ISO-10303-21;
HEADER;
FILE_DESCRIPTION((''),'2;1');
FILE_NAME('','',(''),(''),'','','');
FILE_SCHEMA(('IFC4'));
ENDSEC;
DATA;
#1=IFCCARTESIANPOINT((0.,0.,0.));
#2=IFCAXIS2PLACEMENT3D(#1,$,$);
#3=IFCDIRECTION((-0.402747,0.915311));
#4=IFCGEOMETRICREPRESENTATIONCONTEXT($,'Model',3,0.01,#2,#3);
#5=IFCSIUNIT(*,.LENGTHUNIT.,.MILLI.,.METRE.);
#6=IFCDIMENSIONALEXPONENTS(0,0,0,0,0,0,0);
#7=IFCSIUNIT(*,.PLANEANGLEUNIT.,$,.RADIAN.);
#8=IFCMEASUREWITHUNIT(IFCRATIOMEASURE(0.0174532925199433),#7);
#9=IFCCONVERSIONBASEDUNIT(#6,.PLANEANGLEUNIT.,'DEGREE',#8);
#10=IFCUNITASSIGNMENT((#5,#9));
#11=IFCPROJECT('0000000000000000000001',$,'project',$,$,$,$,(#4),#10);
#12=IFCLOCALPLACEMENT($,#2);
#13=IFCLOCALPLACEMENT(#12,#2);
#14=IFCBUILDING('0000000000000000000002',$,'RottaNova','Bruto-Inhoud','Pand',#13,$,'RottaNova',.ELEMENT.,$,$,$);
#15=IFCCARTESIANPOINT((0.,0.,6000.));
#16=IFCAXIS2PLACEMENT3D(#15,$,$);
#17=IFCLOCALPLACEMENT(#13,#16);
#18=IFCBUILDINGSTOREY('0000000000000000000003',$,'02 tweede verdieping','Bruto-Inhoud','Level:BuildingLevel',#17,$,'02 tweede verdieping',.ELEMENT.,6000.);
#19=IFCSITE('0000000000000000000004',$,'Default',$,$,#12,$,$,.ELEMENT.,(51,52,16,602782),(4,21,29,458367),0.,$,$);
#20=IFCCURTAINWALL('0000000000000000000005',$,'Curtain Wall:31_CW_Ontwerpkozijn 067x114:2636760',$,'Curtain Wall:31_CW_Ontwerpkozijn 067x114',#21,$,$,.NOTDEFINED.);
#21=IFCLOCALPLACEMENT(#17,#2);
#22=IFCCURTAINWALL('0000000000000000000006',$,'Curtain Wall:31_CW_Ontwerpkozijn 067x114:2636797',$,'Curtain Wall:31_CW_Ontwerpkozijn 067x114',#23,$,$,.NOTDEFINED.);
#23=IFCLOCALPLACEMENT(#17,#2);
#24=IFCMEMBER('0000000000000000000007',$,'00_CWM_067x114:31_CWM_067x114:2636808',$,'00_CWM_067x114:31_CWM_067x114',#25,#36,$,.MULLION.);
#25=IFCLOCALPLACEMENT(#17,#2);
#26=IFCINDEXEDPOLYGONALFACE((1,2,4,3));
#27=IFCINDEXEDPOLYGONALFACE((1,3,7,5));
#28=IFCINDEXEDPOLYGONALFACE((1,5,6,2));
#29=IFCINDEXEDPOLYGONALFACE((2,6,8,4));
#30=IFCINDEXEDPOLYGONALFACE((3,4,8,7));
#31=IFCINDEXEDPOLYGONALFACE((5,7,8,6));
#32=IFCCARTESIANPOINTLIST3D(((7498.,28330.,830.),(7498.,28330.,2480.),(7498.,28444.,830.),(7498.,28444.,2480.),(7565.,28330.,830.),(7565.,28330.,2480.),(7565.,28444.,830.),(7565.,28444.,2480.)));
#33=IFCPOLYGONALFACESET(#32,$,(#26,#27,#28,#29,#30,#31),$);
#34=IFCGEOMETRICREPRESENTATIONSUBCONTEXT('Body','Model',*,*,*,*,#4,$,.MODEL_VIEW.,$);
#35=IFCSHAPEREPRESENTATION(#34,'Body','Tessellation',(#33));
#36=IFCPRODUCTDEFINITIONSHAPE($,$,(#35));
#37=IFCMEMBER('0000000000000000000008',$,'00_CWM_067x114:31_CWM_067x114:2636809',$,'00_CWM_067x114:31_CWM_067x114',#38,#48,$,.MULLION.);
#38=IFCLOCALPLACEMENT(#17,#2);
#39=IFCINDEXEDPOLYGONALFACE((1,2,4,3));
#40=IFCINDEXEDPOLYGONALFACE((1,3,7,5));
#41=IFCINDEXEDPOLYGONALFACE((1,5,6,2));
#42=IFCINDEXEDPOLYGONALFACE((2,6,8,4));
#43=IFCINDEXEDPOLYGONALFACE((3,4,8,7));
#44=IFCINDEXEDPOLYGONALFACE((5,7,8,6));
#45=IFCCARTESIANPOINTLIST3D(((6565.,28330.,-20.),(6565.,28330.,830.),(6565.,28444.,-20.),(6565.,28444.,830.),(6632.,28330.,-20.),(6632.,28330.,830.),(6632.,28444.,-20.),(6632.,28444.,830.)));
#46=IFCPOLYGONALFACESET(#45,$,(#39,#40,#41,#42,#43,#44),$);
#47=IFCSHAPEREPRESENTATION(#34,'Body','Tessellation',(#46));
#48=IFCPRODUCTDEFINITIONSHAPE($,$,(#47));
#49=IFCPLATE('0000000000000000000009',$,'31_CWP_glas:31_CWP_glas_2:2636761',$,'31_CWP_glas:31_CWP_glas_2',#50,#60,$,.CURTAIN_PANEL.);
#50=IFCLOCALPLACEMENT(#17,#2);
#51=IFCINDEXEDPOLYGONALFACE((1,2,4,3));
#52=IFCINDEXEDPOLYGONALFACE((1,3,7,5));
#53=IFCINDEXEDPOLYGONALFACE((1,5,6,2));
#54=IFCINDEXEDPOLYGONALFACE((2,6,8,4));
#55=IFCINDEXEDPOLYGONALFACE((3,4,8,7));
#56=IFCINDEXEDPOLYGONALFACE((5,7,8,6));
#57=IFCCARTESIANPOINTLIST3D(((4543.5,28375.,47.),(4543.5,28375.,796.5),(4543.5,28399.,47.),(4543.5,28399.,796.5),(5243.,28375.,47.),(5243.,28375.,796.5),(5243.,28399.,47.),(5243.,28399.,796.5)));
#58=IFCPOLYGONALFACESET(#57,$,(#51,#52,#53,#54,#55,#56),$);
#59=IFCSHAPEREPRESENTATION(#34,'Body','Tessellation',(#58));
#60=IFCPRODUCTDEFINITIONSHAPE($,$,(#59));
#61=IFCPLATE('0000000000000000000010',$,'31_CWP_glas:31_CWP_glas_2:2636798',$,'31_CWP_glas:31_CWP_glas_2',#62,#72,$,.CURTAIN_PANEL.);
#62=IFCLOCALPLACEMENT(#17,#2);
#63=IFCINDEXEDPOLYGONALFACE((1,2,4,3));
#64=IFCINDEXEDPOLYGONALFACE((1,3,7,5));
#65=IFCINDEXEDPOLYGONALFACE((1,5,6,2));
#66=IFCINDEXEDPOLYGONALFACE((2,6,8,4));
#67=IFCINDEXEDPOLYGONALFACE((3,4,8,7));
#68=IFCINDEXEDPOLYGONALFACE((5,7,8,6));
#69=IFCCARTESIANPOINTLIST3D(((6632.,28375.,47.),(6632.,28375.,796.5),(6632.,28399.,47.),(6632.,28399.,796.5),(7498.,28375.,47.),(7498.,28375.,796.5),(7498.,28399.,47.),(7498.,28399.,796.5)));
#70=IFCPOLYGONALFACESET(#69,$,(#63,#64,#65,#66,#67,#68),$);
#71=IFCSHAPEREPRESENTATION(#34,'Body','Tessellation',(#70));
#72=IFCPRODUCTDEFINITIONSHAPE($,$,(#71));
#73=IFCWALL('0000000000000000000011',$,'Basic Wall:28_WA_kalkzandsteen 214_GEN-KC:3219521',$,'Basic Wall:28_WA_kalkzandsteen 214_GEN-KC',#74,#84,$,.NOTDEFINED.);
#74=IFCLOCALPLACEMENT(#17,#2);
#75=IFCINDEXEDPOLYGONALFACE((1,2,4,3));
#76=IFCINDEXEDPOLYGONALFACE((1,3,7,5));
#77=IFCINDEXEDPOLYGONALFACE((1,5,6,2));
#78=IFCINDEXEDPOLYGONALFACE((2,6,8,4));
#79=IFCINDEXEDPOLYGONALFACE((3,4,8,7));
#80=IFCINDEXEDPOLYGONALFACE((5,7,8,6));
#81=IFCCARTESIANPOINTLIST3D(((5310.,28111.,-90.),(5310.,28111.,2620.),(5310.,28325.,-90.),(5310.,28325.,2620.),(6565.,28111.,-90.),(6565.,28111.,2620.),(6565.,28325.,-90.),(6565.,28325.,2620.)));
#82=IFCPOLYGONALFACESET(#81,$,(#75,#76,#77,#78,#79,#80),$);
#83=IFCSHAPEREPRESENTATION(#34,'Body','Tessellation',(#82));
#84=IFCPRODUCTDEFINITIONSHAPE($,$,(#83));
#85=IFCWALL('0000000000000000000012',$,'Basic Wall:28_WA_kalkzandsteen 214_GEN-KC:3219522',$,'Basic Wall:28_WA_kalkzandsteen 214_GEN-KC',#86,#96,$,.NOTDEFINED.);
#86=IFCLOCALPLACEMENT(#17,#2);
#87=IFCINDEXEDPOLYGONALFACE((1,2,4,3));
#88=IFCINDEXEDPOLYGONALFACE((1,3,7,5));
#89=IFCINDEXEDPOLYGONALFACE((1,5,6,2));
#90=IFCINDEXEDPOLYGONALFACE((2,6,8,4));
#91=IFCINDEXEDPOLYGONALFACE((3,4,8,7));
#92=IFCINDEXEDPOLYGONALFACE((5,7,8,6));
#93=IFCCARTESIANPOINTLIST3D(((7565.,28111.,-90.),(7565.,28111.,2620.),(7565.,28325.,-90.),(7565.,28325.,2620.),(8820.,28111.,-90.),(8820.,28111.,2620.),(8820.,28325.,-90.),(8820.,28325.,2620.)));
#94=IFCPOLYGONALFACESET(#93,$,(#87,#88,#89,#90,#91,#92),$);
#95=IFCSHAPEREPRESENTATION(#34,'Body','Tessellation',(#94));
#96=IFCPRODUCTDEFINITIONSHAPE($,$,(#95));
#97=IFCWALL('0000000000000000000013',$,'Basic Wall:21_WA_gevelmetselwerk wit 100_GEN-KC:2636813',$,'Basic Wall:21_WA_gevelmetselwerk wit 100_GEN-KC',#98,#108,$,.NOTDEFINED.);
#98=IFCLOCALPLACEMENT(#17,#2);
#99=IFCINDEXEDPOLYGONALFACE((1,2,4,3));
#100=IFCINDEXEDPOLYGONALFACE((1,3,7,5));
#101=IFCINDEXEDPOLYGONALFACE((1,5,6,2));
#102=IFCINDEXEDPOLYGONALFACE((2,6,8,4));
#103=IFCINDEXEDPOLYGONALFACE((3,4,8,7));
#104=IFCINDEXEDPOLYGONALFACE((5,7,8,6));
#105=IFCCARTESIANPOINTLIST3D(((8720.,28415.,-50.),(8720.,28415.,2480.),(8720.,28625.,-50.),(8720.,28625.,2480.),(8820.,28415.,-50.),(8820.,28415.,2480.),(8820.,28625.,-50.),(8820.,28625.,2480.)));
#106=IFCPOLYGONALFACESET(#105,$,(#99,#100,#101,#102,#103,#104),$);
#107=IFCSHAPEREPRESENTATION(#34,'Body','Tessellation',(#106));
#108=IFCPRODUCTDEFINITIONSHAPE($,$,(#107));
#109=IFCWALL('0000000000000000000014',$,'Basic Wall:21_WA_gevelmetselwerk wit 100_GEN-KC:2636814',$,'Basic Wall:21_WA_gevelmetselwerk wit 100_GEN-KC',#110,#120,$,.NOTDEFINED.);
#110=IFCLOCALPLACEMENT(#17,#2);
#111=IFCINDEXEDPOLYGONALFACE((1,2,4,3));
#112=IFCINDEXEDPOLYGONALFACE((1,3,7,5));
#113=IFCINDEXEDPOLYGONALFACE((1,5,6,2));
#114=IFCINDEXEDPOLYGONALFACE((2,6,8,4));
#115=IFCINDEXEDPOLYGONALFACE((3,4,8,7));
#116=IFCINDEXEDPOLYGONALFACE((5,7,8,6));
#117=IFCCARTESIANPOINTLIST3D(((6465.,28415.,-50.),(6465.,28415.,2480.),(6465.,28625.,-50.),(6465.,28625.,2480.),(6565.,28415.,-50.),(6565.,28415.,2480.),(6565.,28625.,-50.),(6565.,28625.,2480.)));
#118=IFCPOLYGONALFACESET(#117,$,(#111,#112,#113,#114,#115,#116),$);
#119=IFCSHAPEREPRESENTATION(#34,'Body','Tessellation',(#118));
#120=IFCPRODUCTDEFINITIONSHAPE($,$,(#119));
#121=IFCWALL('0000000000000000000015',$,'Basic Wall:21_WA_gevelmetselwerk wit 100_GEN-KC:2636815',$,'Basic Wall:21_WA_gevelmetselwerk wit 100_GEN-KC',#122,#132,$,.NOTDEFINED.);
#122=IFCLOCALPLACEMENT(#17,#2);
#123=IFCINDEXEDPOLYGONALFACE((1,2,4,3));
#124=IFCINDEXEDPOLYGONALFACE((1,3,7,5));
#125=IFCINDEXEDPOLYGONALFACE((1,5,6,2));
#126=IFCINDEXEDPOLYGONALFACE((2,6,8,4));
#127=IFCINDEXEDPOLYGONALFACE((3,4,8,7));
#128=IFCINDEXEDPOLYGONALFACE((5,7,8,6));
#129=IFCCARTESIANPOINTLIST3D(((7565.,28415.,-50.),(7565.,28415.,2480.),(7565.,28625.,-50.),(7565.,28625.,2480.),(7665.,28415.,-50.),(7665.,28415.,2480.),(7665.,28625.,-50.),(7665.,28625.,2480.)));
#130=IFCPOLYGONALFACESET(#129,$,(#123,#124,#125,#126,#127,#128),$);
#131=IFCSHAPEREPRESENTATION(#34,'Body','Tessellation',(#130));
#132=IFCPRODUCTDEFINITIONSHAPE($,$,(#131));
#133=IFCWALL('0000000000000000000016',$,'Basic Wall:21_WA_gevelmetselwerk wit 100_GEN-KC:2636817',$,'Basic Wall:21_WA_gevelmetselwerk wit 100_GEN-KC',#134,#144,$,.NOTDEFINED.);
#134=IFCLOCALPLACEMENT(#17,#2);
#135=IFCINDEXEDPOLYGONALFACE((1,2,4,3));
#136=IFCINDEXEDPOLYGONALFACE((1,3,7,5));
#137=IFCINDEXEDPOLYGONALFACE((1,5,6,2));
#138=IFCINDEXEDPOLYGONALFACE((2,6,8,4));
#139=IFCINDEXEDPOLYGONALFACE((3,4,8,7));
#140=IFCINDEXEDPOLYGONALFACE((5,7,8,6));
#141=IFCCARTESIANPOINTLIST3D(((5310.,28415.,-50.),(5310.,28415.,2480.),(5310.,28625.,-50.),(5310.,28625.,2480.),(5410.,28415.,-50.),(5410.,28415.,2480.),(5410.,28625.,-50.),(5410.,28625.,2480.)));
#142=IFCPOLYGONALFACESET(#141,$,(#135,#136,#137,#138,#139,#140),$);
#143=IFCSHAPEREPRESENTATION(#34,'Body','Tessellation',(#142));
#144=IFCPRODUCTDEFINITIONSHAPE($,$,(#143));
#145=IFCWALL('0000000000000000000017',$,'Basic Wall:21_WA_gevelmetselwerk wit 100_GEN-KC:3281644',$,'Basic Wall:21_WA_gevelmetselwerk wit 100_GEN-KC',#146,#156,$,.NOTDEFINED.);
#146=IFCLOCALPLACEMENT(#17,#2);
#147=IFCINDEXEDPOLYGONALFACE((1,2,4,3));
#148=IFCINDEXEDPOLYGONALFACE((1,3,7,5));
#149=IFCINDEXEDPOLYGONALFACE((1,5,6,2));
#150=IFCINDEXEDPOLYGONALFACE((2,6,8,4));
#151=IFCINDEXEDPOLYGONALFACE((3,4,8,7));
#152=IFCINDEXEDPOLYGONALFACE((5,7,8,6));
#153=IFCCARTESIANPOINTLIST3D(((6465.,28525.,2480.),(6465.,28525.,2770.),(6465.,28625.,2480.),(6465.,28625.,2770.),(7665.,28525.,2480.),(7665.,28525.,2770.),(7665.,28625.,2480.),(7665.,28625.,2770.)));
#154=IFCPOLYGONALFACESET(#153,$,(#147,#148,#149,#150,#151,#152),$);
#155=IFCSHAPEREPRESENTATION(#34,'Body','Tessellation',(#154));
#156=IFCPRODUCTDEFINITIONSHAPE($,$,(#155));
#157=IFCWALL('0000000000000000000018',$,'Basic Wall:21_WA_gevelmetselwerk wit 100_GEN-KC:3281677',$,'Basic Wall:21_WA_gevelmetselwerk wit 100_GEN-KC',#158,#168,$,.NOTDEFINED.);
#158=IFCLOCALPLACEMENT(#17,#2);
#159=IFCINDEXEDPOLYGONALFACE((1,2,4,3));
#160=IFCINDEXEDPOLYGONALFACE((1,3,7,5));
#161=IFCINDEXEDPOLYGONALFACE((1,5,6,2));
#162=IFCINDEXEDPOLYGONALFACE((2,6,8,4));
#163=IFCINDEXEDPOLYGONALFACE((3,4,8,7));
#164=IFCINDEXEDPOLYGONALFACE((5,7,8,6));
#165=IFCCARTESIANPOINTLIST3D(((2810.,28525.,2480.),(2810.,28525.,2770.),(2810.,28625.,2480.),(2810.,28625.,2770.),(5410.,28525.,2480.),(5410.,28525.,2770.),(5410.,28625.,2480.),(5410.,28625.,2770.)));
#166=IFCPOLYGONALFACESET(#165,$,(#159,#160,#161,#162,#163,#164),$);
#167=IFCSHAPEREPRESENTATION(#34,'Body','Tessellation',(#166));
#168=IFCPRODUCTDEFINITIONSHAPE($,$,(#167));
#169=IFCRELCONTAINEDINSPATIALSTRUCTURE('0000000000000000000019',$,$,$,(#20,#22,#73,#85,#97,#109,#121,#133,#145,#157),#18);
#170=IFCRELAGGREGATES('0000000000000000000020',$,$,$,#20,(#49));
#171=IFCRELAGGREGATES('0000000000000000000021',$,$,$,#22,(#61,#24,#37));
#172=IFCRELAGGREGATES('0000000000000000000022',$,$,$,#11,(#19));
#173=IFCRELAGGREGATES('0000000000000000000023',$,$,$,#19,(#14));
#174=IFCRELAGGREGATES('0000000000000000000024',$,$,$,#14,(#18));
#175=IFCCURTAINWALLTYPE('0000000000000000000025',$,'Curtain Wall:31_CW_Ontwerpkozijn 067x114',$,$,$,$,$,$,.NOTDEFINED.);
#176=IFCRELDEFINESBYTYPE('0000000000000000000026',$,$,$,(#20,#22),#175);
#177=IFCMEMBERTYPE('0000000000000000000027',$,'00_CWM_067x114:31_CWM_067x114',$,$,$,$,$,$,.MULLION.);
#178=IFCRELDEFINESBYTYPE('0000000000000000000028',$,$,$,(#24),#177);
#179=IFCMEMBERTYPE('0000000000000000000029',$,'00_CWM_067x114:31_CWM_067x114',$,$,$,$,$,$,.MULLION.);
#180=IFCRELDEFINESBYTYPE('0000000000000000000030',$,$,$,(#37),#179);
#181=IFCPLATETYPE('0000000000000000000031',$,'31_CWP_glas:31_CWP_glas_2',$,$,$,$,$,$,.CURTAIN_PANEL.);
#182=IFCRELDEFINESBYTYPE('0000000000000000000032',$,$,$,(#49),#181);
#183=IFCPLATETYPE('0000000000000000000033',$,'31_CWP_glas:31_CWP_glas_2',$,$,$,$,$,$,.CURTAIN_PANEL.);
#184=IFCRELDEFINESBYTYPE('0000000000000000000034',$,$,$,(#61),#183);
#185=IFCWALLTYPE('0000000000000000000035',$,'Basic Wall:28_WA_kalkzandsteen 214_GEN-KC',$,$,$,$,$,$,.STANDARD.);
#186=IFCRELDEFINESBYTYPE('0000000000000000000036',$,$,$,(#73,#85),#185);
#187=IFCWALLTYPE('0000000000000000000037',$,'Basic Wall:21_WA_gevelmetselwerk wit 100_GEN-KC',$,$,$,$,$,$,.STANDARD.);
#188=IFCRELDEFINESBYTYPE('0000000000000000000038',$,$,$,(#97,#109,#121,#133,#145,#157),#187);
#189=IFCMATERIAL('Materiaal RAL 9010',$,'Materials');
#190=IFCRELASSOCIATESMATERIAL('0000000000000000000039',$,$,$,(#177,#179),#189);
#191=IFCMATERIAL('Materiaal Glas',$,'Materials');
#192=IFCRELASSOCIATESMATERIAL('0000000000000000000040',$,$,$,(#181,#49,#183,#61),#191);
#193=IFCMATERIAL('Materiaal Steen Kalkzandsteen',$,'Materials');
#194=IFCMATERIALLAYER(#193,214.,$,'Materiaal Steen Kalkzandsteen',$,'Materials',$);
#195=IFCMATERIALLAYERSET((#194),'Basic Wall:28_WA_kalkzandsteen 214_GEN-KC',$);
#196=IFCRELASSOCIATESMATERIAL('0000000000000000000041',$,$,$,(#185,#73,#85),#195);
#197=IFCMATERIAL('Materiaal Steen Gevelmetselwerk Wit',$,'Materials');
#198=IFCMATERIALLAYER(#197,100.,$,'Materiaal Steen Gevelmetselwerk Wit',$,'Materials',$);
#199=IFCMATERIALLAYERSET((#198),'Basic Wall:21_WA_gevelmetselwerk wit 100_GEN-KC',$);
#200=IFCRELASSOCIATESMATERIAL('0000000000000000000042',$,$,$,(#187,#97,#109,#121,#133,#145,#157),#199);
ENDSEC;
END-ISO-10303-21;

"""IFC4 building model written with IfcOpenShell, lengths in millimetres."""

from ifc_helpers import new_model, entity, si_unit, converted_unit, direction, frame, frame_2d, origin, origin_2d_with_axis, place, context, subcontext, project, spatial, rectangle, extrude, source, transform, mapped, material, layer, layer_set, material_profile, profile_set, type_object, type_shapes, element, aggregate, save


model = new_model("IFC4")

# Units and contexts
model_context = context("Model", 3, precision=0.01, world=origin(), true_north=direction((-0.402747, 0.915311)))
body_context = subcontext(model_context, "Body", "Model", "MODEL_VIEW")
ifc_project = project(units=[si_unit("LENGTHUNIT", "METRE", prefix="MILLI"), converted_unit("PLANEANGLEUNIT", "DEGREE", entity("IfcRatioMeasure", 0.0174532925199433), si_unit("PLANEANGLEUNIT", "RADIAN"), dimensions=[0, 0, 0, 0, 0, 0, 0])], contexts=[model_context])

# Site, building, storey
site_placement = place(None, origin())
site = spatial("IfcSite", under=ifc_project, at=site_placement, Name="Default", CompositionType="ELEMENT", RefLatitude=(51, 52, 16, 602782), RefLongitude=(4, 21, 29, 458367), RefElevation=0.0)
building_placement = place(site_placement, origin())
building = spatial("IfcBuilding", under=site, at=building_placement, Name="RottaNova", Description="Bruto-Inhoud", ObjectType="Pand", LongName="RottaNova", CompositionType="ELEMENT")
storey_placement = place(building_placement, frame((0.0, 0.0, 6000.0)))
storey = spatial("IfcBuildingStorey", under=building, at=storey_placement, Name="02 tweede verdieping", Description="Bruto-Inhoud", ObjectType="Level:BuildingLevel", LongName="02 tweede verdieping", CompositionType="ELEMENT", Elevation=6000.0)

# Shared definitions
curtain_wall_type = type_object("IfcCurtainWallType", Name="Curtain Wall:31_CW_Ontwerpkozijn 067x114", PredefinedType="NOTDEFINED")
ifc_material_1 = material(Name="Materiaal RAL 9010", Category="Materials")
ifc_material_profile = material_profile(ifc_material_1, rectangle(XDim=114.0, YDim=67.0, at=origin_2d_with_axis()), Name="31_CWM_067x114")
ifc_profile_set = profile_set([ifc_material_profile], Name="31_CWM_067x114")

# Curtain walls
curtain_wall_1_placement = place(storey_placement, frame((0.0, 0.0, -6000.0)))
curtain_wall_1 = element("IfcCurtainWall", 1, at=curtain_wall_1_placement, inside=storey, type_object=curtain_wall_type, Name="Curtain Wall:31_CW_Ontwerpkozijn 067x114:2636760", ObjectType="Curtain Wall:31_CW_Ontwerpkozijn 067x114", PredefinedType="NOTDEFINED")
curtain_wall_2_placement = place(storey_placement, frame((0.0, 0.0, -6000.0)))
curtain_wall_2 = element("IfcCurtainWall", 2, at=curtain_wall_2_placement, inside=storey, type_object=curtain_wall_type, Name="Curtain Wall:31_CW_Ontwerpkozijn 067x114:2636797", ObjectType="Curtain Wall:31_CW_Ontwerpkozijn 067x114", PredefinedType="NOTDEFINED")

# Members
member_type_1 = type_object("IfcMemberType", Name="00_CWM_067x114:31_CWM_067x114", PredefinedType="MULLION", material=ifc_profile_set)
shared_shape_1 = source(origin(), body_context, "Body", "SweptSolid", [
    extrude(rectangle(XDim=114.0, YDim=67.0, at=frame_2d((0.0, 0.0), x_axis=(1.0, 0.0))), frame((-33.5, -57.0, -1650.0), z_axis=(0.0, 0.0, 1.0), x_axis=(0.0, -1.0, 0.0)), (0.0, 0.0, 1.0), 1650.0),
])
type_shapes(member_type_1, [shared_shape_1])
member_1_placement = place(curtain_wall_2_placement, frame((7565.0, 28330.0, 6830.0), z_axis=(0.0, 0.0, -1.0), x_axis=(1.0, 0.0, 0.0)))
member_1 = element("IfcMember", 3, at=member_1_placement, type_object=member_type_1, Name="00_CWM_067x114:31_CWM_067x114:2636808", ObjectType="00_CWM_067x114:31_CWM_067x114", PredefinedType="MULLION", context=body_context, shape_type="MappedRepresentation", body=[
    mapped(shared_shape_1, transform((0.0, 0.0, 0.0), scale=1.0)),
])
member_type_2 = type_object("IfcMemberType", Name="00_CWM_067x114:31_CWM_067x114", PredefinedType="MULLION", material=ifc_profile_set)
shared_shape_2 = source(origin(), body_context, "Body", "SweptSolid", [
    extrude(rectangle(XDim=114.0, YDim=67.0, at=frame_2d((0.0, 0.0), x_axis=(1.0, 0.0))), frame((-33.5, -57.0, -850.0), z_axis=(0.0, 0.0, 1.0), x_axis=(0.0, -1.0, 0.0)), (0.0, 0.0, 1.0), 850.0),
])
type_shapes(member_type_2, [shared_shape_2])
member_2_placement = place(curtain_wall_2_placement, frame((6565.0, 28330.0, 6830.0), z_axis=(0.0, 0.0, 1.0), x_axis=(-1.0, 0.0, 0.0)))
member_2 = element("IfcMember", 4, at=member_2_placement, type_object=member_type_2, Name="00_CWM_067x114:31_CWM_067x114:2636809", ObjectType="00_CWM_067x114:31_CWM_067x114", PredefinedType="MULLION", context=body_context, shape_type="MappedRepresentation", body=[
    mapped(shared_shape_2, transform((0.0, 0.0, 0.0), scale=1.0)),
])

# Plates
ifc_material_2 = material(Name="Materiaal Glas", Category="Materials")
plate_type_1 = type_object("IfcPlateType", Name="31_CWP_glas:31_CWP_glas_2", PredefinedType="CURTAIN_PANEL", material=ifc_material_2)
shared_shape_3 = source(origin(), body_context, "Body", "SweptSolid", [
    extrude(rectangle(XDim=24.0, YDim=699.5, at=frame_2d((0.0, 0.0), x_axis=(1.0, 0.0))), frame((349.8, 12.0, 0.0), z_axis=(0.0, 0.0, 1.0), x_axis=(0.0, 1.0, 0.0)), (0.0, 0.0, 1.0), 749.5),
])
type_shapes(plate_type_1, [shared_shape_3])
plate_1_placement = place(curtain_wall_1_placement, frame((5243.0, 28399.0, 6047.0), z_axis=(0.0, 0.0, 1.0), x_axis=(-1.0, 0.0, 0.0)))
plate_1 = element("IfcPlate", 5, at=plate_1_placement, type_object=plate_type_1, material=ifc_material_2, Name="31_CWP_glas:31_CWP_glas_2:2636761", ObjectType="31_CWP_glas:31_CWP_glas_2", PredefinedType="CURTAIN_PANEL", context=body_context, shape_type="MappedRepresentation", body=[
    mapped(shared_shape_3, transform((0.0, 0.0, 0.0), scale=1.0)),
])
plate_type_2 = type_object("IfcPlateType", Name="31_CWP_glas:31_CWP_glas_2", PredefinedType="CURTAIN_PANEL", material=ifc_material_2)
shared_shape_4 = source(origin(), body_context, "Body", "SweptSolid", [
    extrude(rectangle(XDim=24.0, YDim=866.0, at=frame_2d((0.0, 0.0), x_axis=(1.0, 0.0))), frame((433.0, 12.0, 0.0), z_axis=(0.0, 0.0, 1.0), x_axis=(0.0, 1.0, 0.0)), (0.0, 0.0, 1.0), 749.5),
])
type_shapes(plate_type_2, [shared_shape_4])
plate_2_placement = place(curtain_wall_2_placement, frame((6632.0, 28375.0, 6047.0)))
plate_2 = element("IfcPlate", 6, at=plate_2_placement, type_object=plate_type_2, material=ifc_material_2, Name="31_CWP_glas:31_CWP_glas_2:2636798", ObjectType="31_CWP_glas:31_CWP_glas_2", PredefinedType="CURTAIN_PANEL", context=body_context, shape_type="MappedRepresentation", body=[
    mapped(shared_shape_4, transform((0.0, 0.0, 0.0), scale=1.0)),
])

# Walls
ifc_material_3 = material(Name="Materiaal Steen Kalkzandsteen", Category="Materials")
ifc_layer_1 = layer(ifc_material_3, 214.0, Name="Materiaal Steen Kalkzandsteen", Category="Materials")
ifc_layer_set_1 = layer_set([ifc_layer_1], Name="Basic Wall:28_WA_kalkzandsteen 214_GEN-KC")
wall_type_1 = type_object("IfcWallType", Name="Basic Wall:28_WA_kalkzandsteen 214_GEN-KC", PredefinedType="STANDARD", material=ifc_layer_set_1)
wall_1_placement = place(storey_placement, frame((5310.0, 28218.0, -90.0)))
element("IfcWall", 7, at=wall_1_placement, inside=storey, type_object=wall_type_1, material=ifc_layer_set_1, Name="Basic Wall:28_WA_kalkzandsteen 214_GEN-KC:3219521", ObjectType="Basic Wall:28_WA_kalkzandsteen 214_GEN-KC", PredefinedType="NOTDEFINED", context=body_context, shape_type="SweptSolid", body=[
    extrude(rectangle(XDim=1255.0, YDim=214.0, at=frame_2d((627.5, 0.0), x_axis=(-1.0, 0.0))), origin(), (0.0, 0.0, 1.0), 2710.0),
])
wall_2_placement = place(storey_placement, frame((7565.0, 28218.0, -90.0)))
element("IfcWall", 8, at=wall_2_placement, inside=storey, type_object=wall_type_1, material=ifc_layer_set_1, Name="Basic Wall:28_WA_kalkzandsteen 214_GEN-KC:3219522", ObjectType="Basic Wall:28_WA_kalkzandsteen 214_GEN-KC", PredefinedType="NOTDEFINED", context=body_context, shape_type="SweptSolid", body=[
    extrude(rectangle(XDim=1255.0, YDim=214.0, at=frame_2d((627.5, 0.0), x_axis=(-1.0, 0.0))), origin(), (0.0, 0.0, 1.0), 2710.0),
])
ifc_material_4 = material(Name="Materiaal Steen Gevelmetselwerk Wit", Category="Materials")
ifc_layer_2 = layer(ifc_material_4, 100.0, Name="Materiaal Steen Gevelmetselwerk Wit", Category="Materials")
ifc_layer_set_2 = layer_set([ifc_layer_2], Name="Basic Wall:21_WA_gevelmetselwerk wit 100_GEN-KC")
wall_type_2 = type_object("IfcWallType", Name="Basic Wall:21_WA_gevelmetselwerk wit 100_GEN-KC", PredefinedType="STANDARD", material=ifc_layer_set_2)
wall_3_placement = place(storey_placement, frame((8770.0, 28415.0, -50.0), z_axis=(0.0, 0.0, 1.0), x_axis=(0.0, 1.0, 0.0)))
element("IfcWall", 9, at=wall_3_placement, inside=storey, type_object=wall_type_2, material=ifc_layer_set_2, Name="Basic Wall:21_WA_gevelmetselwerk wit 100_GEN-KC:2636813", ObjectType="Basic Wall:21_WA_gevelmetselwerk wit 100_GEN-KC", PredefinedType="NOTDEFINED", context=body_context, shape_type="SweptSolid", body=[
    extrude(rectangle(XDim=210.0, YDim=100.0, at=frame_2d((105.0, 0.0), x_axis=(-1.0, 0.0))), origin(), (0.0, 0.0, 1.0), 2530.0),
])
wall_4_placement = place(storey_placement, frame((6515.0, 28415.0, -50.0), z_axis=(0.0, 0.0, 1.0), x_axis=(0.0, 1.0, 0.0)))
element("IfcWall", 10, at=wall_4_placement, inside=storey, type_object=wall_type_2, material=ifc_layer_set_2, Name="Basic Wall:21_WA_gevelmetselwerk wit 100_GEN-KC:2636814", ObjectType="Basic Wall:21_WA_gevelmetselwerk wit 100_GEN-KC", PredefinedType="NOTDEFINED", context=body_context, shape_type="SweptSolid", body=[
    extrude(rectangle(XDim=210.0, YDim=100.0, at=frame_2d((105.0, 0.0), x_axis=(-1.0, 0.0))), origin(), (0.0, 0.0, 1.0), 2530.0),
])
wall_5_placement = place(storey_placement, frame((7615.0, 28415.0, -50.0), z_axis=(0.0, 0.0, 1.0), x_axis=(0.0, 1.0, 0.0)))
element("IfcWall", 11, at=wall_5_placement, inside=storey, type_object=wall_type_2, material=ifc_layer_set_2, Name="Basic Wall:21_WA_gevelmetselwerk wit 100_GEN-KC:2636815", ObjectType="Basic Wall:21_WA_gevelmetselwerk wit 100_GEN-KC", PredefinedType="NOTDEFINED", context=body_context, shape_type="SweptSolid", body=[
    extrude(rectangle(XDim=210.0, YDim=100.0, at=frame_2d((105.0, 0.0), x_axis=(-1.0, 0.0))), origin(), (0.0, 0.0, 1.0), 2530.0),
])
wall_6_placement = place(storey_placement, frame((5360.0, 28415.0, -50.0), z_axis=(0.0, 0.0, 1.0), x_axis=(0.0, 1.0, 0.0)))
element("IfcWall", 12, at=wall_6_placement, inside=storey, type_object=wall_type_2, material=ifc_layer_set_2, Name="Basic Wall:21_WA_gevelmetselwerk wit 100_GEN-KC:2636817", ObjectType="Basic Wall:21_WA_gevelmetselwerk wit 100_GEN-KC", PredefinedType="NOTDEFINED", context=body_context, shape_type="SweptSolid", body=[
    extrude(rectangle(XDim=210.0, YDim=100.0, at=frame_2d((105.0, 0.0), x_axis=(-1.0, 0.0))), origin(), (0.0, 0.0, 1.0), 2530.0),
])

# Walls
wall_7_placement = place(storey_placement, frame((7665.0, 28575.0, 2480.0), z_axis=(0.0, 0.0, 1.0), x_axis=(-1.0, 0.0, 0.0)))
element("IfcWall", 13, at=wall_7_placement, inside=storey, type_object=wall_type_2, material=ifc_layer_set_2, Name="Basic Wall:21_WA_gevelmetselwerk wit 100_GEN-KC:3281644", ObjectType="Basic Wall:21_WA_gevelmetselwerk wit 100_GEN-KC", PredefinedType="NOTDEFINED", context=body_context, shape_type="SweptSolid", body=[
    extrude(rectangle(XDim=1200.0, YDim=100.0, at=frame_2d((600.0, 0.0), x_axis=(-1.0, 0.0))), origin(), (0.0, 0.0, 1.0), 290.0),
])
wall_8_placement = place(storey_placement, frame((5410.0, 28575.0, 2480.0), z_axis=(0.0, 0.0, 1.0), x_axis=(-1.0, 0.0, 0.0)))
element("IfcWall", 14, at=wall_8_placement, inside=storey, type_object=wall_type_2, material=ifc_layer_set_2, Name="Basic Wall:21_WA_gevelmetselwerk wit 100_GEN-KC:3281677", ObjectType="Basic Wall:21_WA_gevelmetselwerk wit 100_GEN-KC", PredefinedType="NOTDEFINED", context=body_context, shape_type="SweptSolid", body=[
    extrude(rectangle(XDim=2600.0, YDim=100.0, at=frame_2d((1300.0, 0.0), x_axis=(-1.0, 0.0))), origin(), (0.0, 0.0, 1.0), 290.0),
])

aggregate(curtain_wall_1, [plate_1])

aggregate(curtain_wall_2, [plate_2, member_1, member_2])

save(model, "model.ifc")
